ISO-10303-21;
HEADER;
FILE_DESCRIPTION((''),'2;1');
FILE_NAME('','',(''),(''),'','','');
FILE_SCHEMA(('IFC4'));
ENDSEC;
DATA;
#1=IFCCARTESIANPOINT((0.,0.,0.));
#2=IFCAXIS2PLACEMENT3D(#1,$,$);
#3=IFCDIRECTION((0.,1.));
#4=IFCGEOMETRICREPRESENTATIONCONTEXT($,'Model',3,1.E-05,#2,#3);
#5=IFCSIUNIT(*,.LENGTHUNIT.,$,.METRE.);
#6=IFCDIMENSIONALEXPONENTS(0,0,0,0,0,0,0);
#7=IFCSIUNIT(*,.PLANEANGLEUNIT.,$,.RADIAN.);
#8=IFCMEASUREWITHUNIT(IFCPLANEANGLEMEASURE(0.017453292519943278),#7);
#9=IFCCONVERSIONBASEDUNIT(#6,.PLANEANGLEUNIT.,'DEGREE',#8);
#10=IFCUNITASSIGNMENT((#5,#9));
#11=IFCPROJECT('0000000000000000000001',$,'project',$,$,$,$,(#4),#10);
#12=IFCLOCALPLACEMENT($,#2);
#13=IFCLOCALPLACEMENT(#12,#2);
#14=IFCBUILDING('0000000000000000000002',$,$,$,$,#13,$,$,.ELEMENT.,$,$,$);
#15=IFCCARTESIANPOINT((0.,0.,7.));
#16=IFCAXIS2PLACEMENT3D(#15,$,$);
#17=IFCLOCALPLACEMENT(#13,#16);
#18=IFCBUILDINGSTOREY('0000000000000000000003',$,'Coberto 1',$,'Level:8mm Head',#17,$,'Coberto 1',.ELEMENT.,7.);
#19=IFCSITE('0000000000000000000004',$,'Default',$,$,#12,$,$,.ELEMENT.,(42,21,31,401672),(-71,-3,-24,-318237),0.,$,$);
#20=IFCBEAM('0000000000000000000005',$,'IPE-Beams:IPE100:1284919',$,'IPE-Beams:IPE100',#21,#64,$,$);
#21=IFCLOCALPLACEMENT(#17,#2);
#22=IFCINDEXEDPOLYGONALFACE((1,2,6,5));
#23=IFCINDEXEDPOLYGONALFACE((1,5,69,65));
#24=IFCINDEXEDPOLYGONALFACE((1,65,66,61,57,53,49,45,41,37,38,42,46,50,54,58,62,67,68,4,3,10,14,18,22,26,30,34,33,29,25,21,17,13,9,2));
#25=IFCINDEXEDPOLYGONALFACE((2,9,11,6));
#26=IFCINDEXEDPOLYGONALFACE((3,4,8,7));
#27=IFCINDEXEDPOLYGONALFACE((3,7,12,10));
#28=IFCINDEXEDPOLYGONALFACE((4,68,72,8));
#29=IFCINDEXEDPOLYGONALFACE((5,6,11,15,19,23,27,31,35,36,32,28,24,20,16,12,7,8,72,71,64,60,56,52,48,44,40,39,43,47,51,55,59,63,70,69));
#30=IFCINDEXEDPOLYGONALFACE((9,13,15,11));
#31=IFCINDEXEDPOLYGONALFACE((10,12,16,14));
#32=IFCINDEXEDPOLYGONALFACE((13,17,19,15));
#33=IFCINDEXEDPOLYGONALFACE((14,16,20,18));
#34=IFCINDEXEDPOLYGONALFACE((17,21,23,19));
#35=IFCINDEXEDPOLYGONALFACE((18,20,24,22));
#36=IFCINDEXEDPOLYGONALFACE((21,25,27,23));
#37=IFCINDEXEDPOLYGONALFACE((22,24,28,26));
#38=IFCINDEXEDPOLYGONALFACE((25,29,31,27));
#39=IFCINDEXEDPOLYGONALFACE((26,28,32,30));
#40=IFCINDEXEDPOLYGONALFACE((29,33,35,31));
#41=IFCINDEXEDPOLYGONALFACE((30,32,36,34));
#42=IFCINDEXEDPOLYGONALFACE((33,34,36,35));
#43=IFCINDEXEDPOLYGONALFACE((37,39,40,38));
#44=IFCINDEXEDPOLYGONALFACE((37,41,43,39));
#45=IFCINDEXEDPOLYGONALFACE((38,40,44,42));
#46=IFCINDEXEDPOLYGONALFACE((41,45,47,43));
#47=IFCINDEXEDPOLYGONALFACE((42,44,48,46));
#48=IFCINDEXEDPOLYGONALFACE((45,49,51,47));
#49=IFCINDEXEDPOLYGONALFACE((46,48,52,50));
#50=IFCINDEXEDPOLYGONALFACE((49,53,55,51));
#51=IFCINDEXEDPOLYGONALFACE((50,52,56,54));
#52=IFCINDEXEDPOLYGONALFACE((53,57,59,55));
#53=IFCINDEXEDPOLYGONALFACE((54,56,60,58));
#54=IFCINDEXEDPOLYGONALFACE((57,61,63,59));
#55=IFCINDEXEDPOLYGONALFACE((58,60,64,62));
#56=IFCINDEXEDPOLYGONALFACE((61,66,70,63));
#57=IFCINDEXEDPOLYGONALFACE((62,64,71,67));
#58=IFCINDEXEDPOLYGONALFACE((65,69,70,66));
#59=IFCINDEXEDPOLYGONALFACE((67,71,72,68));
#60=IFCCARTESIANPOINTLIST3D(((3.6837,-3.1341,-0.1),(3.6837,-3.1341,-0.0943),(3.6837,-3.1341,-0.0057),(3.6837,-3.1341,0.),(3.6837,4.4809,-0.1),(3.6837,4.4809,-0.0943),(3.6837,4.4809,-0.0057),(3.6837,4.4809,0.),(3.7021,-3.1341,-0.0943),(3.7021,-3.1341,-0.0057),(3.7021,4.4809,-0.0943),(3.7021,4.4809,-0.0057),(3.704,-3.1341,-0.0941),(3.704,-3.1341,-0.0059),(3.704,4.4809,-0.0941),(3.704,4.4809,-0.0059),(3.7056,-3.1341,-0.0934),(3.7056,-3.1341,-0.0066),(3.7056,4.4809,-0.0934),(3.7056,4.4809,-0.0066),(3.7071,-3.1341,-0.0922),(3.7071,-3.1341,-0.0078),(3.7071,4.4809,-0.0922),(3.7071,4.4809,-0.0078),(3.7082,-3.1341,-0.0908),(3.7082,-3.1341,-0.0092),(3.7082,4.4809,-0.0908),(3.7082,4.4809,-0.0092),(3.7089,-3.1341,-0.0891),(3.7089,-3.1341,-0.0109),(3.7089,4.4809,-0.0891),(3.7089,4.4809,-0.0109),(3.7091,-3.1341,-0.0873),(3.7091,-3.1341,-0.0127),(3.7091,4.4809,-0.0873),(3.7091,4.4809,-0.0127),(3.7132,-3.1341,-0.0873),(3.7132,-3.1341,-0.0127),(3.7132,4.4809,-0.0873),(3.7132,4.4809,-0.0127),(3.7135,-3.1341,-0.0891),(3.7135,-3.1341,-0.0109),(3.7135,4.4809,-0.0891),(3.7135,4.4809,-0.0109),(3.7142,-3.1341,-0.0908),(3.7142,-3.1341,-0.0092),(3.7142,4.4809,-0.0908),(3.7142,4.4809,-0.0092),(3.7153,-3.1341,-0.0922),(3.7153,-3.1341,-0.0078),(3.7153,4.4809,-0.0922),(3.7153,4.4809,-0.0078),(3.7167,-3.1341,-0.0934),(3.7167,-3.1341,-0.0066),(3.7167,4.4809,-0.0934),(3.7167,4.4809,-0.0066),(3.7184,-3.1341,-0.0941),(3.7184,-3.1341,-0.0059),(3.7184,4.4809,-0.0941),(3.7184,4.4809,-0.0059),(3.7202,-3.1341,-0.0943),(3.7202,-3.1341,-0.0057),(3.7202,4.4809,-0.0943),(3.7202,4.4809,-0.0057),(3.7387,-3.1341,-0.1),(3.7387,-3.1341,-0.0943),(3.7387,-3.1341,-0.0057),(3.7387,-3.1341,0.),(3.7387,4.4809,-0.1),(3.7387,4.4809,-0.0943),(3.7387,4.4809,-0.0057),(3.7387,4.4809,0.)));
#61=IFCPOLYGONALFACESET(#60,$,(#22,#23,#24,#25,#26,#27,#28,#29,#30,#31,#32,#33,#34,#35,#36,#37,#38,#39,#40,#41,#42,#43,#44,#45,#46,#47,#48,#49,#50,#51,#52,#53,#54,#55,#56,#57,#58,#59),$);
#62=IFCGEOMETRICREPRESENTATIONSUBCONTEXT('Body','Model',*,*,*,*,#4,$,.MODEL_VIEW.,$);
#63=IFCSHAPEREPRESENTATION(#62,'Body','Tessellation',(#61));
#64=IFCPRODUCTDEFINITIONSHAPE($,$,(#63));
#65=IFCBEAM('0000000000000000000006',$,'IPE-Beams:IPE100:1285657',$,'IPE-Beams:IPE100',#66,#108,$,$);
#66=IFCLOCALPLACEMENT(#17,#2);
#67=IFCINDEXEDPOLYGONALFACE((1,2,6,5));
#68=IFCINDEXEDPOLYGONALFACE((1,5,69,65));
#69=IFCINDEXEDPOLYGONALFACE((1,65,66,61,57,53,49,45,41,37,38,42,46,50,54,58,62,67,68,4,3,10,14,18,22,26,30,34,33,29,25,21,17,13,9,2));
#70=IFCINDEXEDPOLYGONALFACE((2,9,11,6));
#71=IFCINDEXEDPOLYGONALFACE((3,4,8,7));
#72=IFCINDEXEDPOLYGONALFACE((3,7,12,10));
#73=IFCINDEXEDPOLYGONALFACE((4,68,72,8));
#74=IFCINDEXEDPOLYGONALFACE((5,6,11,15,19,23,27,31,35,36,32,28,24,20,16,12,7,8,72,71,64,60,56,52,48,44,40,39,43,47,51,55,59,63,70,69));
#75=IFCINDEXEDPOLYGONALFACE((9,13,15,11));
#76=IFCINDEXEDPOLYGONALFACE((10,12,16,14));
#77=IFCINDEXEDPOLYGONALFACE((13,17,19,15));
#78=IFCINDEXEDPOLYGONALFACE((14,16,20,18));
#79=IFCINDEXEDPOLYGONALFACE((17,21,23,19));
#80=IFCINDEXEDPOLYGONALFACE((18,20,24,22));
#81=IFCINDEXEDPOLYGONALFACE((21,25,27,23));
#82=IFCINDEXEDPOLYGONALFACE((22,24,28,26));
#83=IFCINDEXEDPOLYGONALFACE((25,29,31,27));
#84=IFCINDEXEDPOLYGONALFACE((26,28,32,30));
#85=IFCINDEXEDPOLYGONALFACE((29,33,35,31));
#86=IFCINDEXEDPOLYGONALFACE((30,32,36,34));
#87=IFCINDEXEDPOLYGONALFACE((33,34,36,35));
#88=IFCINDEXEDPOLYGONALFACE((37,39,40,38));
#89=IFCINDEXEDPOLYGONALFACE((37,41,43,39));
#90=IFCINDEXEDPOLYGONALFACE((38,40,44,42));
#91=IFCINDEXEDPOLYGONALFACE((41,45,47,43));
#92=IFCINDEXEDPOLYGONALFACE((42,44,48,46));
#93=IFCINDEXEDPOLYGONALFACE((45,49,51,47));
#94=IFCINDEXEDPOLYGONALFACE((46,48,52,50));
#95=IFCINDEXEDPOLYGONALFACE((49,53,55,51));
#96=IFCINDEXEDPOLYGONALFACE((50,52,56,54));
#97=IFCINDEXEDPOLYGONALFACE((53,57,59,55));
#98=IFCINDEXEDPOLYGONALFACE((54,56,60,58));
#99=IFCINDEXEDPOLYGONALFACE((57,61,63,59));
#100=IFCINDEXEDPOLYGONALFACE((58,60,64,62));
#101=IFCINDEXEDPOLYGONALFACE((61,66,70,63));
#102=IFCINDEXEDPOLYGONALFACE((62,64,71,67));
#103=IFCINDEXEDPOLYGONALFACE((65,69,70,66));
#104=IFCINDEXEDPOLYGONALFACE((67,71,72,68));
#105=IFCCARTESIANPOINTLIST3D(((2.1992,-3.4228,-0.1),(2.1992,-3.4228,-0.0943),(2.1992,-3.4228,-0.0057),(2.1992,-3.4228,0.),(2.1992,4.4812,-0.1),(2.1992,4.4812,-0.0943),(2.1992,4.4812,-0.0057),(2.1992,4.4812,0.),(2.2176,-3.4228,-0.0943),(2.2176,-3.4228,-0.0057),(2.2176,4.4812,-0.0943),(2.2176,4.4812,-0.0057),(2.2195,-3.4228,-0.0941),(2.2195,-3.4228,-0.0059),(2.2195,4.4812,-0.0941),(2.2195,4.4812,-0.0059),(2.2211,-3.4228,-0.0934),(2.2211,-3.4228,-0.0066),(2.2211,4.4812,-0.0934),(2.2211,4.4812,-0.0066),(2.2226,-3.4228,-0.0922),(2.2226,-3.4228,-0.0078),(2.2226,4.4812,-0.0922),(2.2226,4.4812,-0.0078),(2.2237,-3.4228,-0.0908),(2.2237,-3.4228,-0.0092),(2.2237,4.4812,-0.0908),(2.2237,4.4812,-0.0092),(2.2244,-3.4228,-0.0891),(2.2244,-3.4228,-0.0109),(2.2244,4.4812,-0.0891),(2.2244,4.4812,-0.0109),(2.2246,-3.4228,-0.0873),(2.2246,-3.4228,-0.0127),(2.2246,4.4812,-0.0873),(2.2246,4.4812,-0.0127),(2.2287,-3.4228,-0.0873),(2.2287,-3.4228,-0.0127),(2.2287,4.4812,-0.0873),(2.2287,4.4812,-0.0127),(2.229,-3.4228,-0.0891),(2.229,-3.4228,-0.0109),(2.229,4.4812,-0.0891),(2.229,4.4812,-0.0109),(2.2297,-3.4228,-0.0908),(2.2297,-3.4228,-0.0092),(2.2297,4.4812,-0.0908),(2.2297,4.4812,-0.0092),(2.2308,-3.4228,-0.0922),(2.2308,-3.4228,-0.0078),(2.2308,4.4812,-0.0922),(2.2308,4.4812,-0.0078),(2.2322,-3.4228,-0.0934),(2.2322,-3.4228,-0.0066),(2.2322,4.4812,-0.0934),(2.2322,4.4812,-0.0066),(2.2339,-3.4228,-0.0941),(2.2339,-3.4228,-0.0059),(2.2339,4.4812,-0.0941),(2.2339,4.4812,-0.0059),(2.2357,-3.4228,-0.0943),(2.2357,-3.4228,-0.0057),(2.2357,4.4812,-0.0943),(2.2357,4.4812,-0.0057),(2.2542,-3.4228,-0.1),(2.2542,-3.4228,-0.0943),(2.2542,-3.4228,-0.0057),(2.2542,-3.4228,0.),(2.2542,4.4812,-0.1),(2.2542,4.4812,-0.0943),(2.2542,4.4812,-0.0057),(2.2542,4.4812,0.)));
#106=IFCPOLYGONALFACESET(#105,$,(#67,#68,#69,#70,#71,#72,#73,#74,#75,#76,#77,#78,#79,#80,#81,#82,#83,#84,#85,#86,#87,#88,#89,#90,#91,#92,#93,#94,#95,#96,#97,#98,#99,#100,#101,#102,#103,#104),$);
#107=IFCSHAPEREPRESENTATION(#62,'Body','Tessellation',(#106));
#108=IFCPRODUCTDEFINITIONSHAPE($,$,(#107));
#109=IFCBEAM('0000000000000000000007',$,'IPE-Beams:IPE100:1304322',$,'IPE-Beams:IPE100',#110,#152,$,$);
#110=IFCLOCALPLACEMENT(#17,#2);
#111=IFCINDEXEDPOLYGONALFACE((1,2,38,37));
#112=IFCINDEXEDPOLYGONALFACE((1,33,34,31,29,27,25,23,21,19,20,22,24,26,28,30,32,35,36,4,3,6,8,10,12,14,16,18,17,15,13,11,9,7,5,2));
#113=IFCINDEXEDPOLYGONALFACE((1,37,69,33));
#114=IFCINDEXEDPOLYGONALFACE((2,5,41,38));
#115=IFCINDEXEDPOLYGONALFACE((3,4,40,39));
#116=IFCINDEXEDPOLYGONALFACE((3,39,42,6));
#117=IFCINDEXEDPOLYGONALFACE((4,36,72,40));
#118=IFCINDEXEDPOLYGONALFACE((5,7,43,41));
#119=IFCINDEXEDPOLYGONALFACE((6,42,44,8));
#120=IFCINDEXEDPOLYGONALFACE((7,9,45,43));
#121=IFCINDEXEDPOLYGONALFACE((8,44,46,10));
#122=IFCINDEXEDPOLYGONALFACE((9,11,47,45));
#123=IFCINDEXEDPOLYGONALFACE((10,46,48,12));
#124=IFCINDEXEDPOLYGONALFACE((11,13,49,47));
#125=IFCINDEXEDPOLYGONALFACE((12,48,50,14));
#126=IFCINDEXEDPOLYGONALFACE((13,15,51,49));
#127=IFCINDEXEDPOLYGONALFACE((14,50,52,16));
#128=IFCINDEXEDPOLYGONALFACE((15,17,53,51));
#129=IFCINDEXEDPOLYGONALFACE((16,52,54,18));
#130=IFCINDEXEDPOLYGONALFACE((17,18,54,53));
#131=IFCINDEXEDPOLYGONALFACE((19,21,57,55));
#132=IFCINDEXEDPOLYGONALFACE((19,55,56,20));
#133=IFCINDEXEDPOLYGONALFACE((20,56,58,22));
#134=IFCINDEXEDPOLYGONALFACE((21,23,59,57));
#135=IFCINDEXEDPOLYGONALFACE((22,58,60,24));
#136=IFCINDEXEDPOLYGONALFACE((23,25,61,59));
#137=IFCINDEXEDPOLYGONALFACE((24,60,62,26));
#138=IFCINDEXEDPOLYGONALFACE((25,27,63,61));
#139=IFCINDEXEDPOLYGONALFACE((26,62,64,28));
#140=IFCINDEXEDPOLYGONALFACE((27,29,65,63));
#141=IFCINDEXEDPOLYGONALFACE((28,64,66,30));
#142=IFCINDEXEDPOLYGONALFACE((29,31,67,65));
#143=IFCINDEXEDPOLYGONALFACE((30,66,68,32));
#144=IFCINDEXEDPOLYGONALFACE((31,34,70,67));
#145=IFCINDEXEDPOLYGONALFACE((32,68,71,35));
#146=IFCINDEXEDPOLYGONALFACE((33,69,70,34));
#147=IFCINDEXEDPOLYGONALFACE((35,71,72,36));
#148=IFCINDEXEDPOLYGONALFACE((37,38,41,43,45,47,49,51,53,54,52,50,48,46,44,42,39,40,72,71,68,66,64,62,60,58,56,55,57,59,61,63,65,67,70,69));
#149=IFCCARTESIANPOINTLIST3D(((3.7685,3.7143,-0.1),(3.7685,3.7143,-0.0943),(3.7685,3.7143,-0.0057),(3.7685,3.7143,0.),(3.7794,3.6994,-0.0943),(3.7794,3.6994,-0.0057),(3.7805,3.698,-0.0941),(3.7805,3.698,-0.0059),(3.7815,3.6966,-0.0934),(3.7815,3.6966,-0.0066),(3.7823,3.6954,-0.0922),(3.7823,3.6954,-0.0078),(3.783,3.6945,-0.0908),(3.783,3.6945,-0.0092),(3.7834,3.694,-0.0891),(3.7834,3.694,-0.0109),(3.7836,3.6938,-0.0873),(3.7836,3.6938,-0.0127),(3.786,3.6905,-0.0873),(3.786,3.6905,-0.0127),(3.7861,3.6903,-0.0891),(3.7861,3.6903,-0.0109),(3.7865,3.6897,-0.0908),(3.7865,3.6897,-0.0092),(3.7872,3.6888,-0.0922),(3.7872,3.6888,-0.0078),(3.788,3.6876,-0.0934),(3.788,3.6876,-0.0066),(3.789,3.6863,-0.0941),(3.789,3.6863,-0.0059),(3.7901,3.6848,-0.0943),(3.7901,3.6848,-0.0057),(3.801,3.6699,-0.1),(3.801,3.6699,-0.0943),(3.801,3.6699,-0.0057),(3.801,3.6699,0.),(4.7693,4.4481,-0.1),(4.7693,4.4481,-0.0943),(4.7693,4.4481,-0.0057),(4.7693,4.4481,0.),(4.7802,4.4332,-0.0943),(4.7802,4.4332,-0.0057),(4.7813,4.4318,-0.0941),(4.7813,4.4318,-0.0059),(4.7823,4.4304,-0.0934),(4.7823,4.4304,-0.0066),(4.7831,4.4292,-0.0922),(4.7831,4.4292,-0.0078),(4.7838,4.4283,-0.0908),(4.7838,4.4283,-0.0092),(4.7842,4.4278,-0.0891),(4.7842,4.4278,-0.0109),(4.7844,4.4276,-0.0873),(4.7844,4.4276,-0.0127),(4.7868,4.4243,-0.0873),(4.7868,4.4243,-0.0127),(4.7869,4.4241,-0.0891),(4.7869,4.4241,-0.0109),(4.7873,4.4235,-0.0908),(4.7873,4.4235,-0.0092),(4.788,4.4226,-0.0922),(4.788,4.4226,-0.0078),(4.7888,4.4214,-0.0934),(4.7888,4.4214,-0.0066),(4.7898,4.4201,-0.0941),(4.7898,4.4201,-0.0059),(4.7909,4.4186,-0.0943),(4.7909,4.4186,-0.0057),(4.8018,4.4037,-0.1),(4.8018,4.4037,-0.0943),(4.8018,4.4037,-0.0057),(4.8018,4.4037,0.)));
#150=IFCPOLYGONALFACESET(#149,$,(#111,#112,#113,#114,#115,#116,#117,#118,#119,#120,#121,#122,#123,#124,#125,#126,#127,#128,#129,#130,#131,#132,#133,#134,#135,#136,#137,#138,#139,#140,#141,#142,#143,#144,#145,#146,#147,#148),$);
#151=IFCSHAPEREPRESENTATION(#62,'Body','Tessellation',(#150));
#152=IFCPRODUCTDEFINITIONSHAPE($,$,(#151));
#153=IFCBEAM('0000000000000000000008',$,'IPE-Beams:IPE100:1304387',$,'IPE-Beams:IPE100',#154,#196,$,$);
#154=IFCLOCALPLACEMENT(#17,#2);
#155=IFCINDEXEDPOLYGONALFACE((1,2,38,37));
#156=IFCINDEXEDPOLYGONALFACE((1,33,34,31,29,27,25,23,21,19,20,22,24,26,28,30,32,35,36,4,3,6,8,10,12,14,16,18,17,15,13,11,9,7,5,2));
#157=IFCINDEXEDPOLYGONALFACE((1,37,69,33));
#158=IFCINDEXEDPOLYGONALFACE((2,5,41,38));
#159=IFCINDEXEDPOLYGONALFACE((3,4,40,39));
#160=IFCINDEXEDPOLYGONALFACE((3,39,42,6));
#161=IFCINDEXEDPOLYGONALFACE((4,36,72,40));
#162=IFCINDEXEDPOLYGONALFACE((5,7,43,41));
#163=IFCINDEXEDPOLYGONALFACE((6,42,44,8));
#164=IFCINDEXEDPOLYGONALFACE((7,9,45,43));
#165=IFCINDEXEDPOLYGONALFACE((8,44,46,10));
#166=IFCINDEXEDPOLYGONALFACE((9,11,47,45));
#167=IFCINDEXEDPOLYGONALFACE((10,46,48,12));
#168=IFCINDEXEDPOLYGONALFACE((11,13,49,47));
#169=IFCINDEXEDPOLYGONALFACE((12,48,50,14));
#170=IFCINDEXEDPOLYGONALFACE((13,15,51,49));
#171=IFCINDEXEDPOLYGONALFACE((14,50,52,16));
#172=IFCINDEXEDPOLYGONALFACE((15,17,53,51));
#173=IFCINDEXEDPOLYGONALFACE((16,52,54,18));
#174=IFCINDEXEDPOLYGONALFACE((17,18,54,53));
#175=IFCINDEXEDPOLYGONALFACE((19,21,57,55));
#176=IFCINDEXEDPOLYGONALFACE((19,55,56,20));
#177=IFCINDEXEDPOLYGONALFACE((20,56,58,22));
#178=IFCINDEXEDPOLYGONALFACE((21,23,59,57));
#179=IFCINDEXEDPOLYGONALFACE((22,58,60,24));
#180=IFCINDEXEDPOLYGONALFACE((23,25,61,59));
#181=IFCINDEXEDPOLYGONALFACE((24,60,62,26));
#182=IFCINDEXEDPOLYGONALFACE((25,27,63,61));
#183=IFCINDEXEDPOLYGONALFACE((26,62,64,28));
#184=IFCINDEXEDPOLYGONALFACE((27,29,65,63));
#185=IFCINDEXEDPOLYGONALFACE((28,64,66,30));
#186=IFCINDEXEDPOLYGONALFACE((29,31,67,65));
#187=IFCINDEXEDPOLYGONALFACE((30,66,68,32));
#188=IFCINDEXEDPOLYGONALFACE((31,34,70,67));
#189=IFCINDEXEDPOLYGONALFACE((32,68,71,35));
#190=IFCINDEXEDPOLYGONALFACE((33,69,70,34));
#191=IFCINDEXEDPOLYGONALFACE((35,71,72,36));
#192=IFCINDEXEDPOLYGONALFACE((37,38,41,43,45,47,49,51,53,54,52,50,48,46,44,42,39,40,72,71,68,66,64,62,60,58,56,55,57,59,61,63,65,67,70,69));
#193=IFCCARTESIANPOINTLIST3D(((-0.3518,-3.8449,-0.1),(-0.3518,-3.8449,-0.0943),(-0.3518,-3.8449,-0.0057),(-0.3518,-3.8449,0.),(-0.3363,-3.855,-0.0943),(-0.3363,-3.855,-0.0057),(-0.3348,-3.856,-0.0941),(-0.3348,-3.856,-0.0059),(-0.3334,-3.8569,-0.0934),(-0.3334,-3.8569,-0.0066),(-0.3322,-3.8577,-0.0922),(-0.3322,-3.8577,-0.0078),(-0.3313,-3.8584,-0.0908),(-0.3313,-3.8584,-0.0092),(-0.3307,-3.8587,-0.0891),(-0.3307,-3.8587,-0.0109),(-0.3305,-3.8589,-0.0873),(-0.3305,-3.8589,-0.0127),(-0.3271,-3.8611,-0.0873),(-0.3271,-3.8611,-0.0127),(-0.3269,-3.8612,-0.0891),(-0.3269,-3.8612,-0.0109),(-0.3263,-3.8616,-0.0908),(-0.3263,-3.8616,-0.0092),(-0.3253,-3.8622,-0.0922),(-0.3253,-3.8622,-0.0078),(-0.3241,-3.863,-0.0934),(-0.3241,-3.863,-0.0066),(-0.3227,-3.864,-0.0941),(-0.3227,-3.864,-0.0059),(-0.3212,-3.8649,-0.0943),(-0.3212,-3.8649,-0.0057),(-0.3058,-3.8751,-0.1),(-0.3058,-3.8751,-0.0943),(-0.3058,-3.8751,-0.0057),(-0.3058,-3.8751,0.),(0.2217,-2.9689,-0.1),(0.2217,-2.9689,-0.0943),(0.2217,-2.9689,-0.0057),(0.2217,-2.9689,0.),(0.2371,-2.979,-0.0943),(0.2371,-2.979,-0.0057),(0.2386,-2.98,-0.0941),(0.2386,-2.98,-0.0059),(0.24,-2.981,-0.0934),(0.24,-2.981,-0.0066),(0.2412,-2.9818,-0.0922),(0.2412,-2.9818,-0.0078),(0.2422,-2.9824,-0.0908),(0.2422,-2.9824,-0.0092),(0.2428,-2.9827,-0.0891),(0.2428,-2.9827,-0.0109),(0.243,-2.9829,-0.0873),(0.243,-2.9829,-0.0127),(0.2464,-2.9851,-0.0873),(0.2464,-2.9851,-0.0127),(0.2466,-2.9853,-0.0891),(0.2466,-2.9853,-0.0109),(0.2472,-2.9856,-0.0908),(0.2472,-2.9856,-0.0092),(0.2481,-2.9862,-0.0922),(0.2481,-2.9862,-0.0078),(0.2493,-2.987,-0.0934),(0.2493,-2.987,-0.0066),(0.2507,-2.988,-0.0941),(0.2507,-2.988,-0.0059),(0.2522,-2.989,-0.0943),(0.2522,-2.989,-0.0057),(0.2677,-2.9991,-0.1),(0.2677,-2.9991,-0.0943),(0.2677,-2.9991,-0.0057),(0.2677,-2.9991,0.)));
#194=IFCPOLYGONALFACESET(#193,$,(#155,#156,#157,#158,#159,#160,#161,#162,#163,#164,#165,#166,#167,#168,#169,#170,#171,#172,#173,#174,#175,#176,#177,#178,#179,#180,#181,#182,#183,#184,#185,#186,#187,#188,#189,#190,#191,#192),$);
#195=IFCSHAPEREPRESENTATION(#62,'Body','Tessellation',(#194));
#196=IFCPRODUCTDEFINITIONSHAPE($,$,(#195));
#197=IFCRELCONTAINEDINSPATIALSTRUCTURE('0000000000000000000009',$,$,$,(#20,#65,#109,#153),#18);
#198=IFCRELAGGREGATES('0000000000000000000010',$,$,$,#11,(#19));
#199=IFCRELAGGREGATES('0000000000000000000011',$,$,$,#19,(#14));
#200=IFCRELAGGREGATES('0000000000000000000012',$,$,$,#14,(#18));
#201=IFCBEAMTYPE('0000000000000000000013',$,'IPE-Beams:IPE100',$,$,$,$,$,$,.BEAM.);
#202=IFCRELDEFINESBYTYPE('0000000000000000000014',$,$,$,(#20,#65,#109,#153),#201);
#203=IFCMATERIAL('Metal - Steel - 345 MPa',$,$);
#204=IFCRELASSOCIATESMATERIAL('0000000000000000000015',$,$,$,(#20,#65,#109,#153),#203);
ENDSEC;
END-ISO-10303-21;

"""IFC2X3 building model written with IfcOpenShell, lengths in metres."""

from ifc_helpers import new_model, entity, si_unit, converted_unit, direction, frame, frame_2d, origin, place, context, subcontext, project, spatial, i_section, extrude, material, type_object, element, save


model = new_model("IFC2X3")

# Units and contexts
model_context = context("Model", 3, precision=1e-05, world=origin(), true_north=direction((0.0, 1.0)))
body_context = subcontext(model_context, "Body", "Model", "MODEL_VIEW")
ifc_project = project(units=[si_unit("LENGTHUNIT", "METRE"), converted_unit("PLANEANGLEUNIT", "DEGREE", entity("IfcPlaneAngleMeasure", 0.017453292519943278), si_unit("PLANEANGLEUNIT", "RADIAN"), dimensions=[0, 0, 0, 0, 0, 0, 0])], contexts=[model_context])

# Site, building, storey
site_placement = place(None, origin())
site = spatial("IfcSite", under=ifc_project, at=site_placement, Name="Default", CompositionType="ELEMENT", RefLatitude=(42, 21, 31, 401672), RefLongitude=(-71, -3, -24, -318237), RefElevation=0.0)
building_placement = place(site_placement, origin())
building = spatial("IfcBuilding", under=site, at=building_placement, CompositionType="ELEMENT")
storey_placement = place(building_placement, frame((0.0, 0.0, 7.0)))
storey = spatial("IfcBuildingStorey", under=building, at=storey_placement, Name="Coberto 1", ObjectType="Level:8mm Head", LongName="Coberto 1", CompositionType="ELEMENT", Elevation=7.0)

# Shared definitions
ifc_material_1 = material(Name="Metal - Steel - 345 MPa")

# Beams
beam_type_1 = type_object("IfcBeamType", Name="IPE-Beams:IPE100", PredefinedType="BEAM")
beam_1_placement = place(storey_placement, frame((3.7387, 4.4862, 0.0), z_axis=(0.0, 0.0, 1.0), x_axis=(0.0, -1.0, 0.0)))
element("IfcBeam", 1, at=beam_1_placement, inside=storey, type_object=beam_type_1, material=ifc_material_1, Name="IPE-Beams:IPE100:1284919", ObjectType="IPE-Beams:IPE100", context=body_context, shape_type="SweptSolid", body=[
    extrude(i_section(OverallWidth=0.055, OverallDepth=0.1, WebThickness=0.0041, FlangeThickness=0.0057, FilletRadius=0.007, at=frame_2d((0.0, 0.0), x_axis=(0.0, 1.0))), frame((0.0054, -0.0275, -0.05), z_axis=(1.0, 0.0, 0.0), x_axis=(0.0, 0.0, -1.0)), (0.0, 0.0, 1.0), 7.615),
])
beam_2_placement = place(storey_placement, frame((2.2267, 4.4862, 0.0), z_axis=(0.0, 0.0, 1.0), x_axis=(0.0, -1.0, 0.0)))
element("IfcBeam", 2, at=beam_2_placement, inside=storey, type_object=beam_type_1, material=ifc_material_1, Name="IPE-Beams:IPE100:1285657", ObjectType="IPE-Beams:IPE100", context=body_context, shape_type="SweptSolid", body=[
    extrude(i_section(OverallWidth=0.055, OverallDepth=0.1, WebThickness=0.0041, FlangeThickness=0.0057, FilletRadius=0.007, at=frame_2d((0.0, 0.0), x_axis=(0.0, 1.0))), frame((0.0051, 0.0, -0.05), z_axis=(1.0, 0.0, 0.0), x_axis=(0.0, 0.0, -1.0)), (0.0, 0.0, 1.0), 7.904),
])
beam_3_placement = place(storey_placement, frame((3.7067, 3.6349, 0.0), z_axis=(0.0, 0.0, 1.0), x_axis=(0.806451, 0.591301, 0.0)))
element("IfcBeam", 3, at=beam_3_placement, inside=storey, type_object=beam_type_1, material=ifc_material_1, Name="IPE-Beams:IPE100:1304322", ObjectType="IPE-Beams:IPE100", context=body_context, shape_type="SweptSolid", body=[
    extrude(i_section(OverallWidth=0.055, OverallDepth=0.1, WebThickness=0.0041, FlangeThickness=0.0057, FilletRadius=0.007, at=frame_2d((0.0, 0.0), x_axis=(0.0, 1.0))), frame((0.0968, 0.0, -0.05), z_axis=(1.0, 0.0, 0.0), x_axis=(0.0, 0.0, -1.0)), (0.0, 0.0, 1.0), 1.241),
])
beam_4_placement = place(storey_placement, frame((0.2747, -2.9381, 0.0), z_axis=(0.0, 0.0, 1.0), x_axis=(-0.547712, -0.836667, 0.0)))
element("IfcBeam", 4, at=beam_4_placement, inside=storey, type_object=beam_type_1, material=ifc_material_1, Name="IPE-Beams:IPE100:1304387", ObjectType="IPE-Beams:IPE100", context=body_context, shape_type="SweptSolid", body=[
    extrude(i_section(OverallWidth=0.055, OverallDepth=0.1, WebThickness=0.0041, FlangeThickness=0.0057, FilletRadius=0.007, at=frame_2d((0.0, 0.0), x_axis=(0.0, 1.0))), frame((0.0548, 0.0, -0.05), z_axis=(1.0, 0.0, 0.0), x_axis=(0.0, 0.0, -1.0)), (0.0, 0.0, 1.0), 1.047),
])

save(model, "model.ifc")
